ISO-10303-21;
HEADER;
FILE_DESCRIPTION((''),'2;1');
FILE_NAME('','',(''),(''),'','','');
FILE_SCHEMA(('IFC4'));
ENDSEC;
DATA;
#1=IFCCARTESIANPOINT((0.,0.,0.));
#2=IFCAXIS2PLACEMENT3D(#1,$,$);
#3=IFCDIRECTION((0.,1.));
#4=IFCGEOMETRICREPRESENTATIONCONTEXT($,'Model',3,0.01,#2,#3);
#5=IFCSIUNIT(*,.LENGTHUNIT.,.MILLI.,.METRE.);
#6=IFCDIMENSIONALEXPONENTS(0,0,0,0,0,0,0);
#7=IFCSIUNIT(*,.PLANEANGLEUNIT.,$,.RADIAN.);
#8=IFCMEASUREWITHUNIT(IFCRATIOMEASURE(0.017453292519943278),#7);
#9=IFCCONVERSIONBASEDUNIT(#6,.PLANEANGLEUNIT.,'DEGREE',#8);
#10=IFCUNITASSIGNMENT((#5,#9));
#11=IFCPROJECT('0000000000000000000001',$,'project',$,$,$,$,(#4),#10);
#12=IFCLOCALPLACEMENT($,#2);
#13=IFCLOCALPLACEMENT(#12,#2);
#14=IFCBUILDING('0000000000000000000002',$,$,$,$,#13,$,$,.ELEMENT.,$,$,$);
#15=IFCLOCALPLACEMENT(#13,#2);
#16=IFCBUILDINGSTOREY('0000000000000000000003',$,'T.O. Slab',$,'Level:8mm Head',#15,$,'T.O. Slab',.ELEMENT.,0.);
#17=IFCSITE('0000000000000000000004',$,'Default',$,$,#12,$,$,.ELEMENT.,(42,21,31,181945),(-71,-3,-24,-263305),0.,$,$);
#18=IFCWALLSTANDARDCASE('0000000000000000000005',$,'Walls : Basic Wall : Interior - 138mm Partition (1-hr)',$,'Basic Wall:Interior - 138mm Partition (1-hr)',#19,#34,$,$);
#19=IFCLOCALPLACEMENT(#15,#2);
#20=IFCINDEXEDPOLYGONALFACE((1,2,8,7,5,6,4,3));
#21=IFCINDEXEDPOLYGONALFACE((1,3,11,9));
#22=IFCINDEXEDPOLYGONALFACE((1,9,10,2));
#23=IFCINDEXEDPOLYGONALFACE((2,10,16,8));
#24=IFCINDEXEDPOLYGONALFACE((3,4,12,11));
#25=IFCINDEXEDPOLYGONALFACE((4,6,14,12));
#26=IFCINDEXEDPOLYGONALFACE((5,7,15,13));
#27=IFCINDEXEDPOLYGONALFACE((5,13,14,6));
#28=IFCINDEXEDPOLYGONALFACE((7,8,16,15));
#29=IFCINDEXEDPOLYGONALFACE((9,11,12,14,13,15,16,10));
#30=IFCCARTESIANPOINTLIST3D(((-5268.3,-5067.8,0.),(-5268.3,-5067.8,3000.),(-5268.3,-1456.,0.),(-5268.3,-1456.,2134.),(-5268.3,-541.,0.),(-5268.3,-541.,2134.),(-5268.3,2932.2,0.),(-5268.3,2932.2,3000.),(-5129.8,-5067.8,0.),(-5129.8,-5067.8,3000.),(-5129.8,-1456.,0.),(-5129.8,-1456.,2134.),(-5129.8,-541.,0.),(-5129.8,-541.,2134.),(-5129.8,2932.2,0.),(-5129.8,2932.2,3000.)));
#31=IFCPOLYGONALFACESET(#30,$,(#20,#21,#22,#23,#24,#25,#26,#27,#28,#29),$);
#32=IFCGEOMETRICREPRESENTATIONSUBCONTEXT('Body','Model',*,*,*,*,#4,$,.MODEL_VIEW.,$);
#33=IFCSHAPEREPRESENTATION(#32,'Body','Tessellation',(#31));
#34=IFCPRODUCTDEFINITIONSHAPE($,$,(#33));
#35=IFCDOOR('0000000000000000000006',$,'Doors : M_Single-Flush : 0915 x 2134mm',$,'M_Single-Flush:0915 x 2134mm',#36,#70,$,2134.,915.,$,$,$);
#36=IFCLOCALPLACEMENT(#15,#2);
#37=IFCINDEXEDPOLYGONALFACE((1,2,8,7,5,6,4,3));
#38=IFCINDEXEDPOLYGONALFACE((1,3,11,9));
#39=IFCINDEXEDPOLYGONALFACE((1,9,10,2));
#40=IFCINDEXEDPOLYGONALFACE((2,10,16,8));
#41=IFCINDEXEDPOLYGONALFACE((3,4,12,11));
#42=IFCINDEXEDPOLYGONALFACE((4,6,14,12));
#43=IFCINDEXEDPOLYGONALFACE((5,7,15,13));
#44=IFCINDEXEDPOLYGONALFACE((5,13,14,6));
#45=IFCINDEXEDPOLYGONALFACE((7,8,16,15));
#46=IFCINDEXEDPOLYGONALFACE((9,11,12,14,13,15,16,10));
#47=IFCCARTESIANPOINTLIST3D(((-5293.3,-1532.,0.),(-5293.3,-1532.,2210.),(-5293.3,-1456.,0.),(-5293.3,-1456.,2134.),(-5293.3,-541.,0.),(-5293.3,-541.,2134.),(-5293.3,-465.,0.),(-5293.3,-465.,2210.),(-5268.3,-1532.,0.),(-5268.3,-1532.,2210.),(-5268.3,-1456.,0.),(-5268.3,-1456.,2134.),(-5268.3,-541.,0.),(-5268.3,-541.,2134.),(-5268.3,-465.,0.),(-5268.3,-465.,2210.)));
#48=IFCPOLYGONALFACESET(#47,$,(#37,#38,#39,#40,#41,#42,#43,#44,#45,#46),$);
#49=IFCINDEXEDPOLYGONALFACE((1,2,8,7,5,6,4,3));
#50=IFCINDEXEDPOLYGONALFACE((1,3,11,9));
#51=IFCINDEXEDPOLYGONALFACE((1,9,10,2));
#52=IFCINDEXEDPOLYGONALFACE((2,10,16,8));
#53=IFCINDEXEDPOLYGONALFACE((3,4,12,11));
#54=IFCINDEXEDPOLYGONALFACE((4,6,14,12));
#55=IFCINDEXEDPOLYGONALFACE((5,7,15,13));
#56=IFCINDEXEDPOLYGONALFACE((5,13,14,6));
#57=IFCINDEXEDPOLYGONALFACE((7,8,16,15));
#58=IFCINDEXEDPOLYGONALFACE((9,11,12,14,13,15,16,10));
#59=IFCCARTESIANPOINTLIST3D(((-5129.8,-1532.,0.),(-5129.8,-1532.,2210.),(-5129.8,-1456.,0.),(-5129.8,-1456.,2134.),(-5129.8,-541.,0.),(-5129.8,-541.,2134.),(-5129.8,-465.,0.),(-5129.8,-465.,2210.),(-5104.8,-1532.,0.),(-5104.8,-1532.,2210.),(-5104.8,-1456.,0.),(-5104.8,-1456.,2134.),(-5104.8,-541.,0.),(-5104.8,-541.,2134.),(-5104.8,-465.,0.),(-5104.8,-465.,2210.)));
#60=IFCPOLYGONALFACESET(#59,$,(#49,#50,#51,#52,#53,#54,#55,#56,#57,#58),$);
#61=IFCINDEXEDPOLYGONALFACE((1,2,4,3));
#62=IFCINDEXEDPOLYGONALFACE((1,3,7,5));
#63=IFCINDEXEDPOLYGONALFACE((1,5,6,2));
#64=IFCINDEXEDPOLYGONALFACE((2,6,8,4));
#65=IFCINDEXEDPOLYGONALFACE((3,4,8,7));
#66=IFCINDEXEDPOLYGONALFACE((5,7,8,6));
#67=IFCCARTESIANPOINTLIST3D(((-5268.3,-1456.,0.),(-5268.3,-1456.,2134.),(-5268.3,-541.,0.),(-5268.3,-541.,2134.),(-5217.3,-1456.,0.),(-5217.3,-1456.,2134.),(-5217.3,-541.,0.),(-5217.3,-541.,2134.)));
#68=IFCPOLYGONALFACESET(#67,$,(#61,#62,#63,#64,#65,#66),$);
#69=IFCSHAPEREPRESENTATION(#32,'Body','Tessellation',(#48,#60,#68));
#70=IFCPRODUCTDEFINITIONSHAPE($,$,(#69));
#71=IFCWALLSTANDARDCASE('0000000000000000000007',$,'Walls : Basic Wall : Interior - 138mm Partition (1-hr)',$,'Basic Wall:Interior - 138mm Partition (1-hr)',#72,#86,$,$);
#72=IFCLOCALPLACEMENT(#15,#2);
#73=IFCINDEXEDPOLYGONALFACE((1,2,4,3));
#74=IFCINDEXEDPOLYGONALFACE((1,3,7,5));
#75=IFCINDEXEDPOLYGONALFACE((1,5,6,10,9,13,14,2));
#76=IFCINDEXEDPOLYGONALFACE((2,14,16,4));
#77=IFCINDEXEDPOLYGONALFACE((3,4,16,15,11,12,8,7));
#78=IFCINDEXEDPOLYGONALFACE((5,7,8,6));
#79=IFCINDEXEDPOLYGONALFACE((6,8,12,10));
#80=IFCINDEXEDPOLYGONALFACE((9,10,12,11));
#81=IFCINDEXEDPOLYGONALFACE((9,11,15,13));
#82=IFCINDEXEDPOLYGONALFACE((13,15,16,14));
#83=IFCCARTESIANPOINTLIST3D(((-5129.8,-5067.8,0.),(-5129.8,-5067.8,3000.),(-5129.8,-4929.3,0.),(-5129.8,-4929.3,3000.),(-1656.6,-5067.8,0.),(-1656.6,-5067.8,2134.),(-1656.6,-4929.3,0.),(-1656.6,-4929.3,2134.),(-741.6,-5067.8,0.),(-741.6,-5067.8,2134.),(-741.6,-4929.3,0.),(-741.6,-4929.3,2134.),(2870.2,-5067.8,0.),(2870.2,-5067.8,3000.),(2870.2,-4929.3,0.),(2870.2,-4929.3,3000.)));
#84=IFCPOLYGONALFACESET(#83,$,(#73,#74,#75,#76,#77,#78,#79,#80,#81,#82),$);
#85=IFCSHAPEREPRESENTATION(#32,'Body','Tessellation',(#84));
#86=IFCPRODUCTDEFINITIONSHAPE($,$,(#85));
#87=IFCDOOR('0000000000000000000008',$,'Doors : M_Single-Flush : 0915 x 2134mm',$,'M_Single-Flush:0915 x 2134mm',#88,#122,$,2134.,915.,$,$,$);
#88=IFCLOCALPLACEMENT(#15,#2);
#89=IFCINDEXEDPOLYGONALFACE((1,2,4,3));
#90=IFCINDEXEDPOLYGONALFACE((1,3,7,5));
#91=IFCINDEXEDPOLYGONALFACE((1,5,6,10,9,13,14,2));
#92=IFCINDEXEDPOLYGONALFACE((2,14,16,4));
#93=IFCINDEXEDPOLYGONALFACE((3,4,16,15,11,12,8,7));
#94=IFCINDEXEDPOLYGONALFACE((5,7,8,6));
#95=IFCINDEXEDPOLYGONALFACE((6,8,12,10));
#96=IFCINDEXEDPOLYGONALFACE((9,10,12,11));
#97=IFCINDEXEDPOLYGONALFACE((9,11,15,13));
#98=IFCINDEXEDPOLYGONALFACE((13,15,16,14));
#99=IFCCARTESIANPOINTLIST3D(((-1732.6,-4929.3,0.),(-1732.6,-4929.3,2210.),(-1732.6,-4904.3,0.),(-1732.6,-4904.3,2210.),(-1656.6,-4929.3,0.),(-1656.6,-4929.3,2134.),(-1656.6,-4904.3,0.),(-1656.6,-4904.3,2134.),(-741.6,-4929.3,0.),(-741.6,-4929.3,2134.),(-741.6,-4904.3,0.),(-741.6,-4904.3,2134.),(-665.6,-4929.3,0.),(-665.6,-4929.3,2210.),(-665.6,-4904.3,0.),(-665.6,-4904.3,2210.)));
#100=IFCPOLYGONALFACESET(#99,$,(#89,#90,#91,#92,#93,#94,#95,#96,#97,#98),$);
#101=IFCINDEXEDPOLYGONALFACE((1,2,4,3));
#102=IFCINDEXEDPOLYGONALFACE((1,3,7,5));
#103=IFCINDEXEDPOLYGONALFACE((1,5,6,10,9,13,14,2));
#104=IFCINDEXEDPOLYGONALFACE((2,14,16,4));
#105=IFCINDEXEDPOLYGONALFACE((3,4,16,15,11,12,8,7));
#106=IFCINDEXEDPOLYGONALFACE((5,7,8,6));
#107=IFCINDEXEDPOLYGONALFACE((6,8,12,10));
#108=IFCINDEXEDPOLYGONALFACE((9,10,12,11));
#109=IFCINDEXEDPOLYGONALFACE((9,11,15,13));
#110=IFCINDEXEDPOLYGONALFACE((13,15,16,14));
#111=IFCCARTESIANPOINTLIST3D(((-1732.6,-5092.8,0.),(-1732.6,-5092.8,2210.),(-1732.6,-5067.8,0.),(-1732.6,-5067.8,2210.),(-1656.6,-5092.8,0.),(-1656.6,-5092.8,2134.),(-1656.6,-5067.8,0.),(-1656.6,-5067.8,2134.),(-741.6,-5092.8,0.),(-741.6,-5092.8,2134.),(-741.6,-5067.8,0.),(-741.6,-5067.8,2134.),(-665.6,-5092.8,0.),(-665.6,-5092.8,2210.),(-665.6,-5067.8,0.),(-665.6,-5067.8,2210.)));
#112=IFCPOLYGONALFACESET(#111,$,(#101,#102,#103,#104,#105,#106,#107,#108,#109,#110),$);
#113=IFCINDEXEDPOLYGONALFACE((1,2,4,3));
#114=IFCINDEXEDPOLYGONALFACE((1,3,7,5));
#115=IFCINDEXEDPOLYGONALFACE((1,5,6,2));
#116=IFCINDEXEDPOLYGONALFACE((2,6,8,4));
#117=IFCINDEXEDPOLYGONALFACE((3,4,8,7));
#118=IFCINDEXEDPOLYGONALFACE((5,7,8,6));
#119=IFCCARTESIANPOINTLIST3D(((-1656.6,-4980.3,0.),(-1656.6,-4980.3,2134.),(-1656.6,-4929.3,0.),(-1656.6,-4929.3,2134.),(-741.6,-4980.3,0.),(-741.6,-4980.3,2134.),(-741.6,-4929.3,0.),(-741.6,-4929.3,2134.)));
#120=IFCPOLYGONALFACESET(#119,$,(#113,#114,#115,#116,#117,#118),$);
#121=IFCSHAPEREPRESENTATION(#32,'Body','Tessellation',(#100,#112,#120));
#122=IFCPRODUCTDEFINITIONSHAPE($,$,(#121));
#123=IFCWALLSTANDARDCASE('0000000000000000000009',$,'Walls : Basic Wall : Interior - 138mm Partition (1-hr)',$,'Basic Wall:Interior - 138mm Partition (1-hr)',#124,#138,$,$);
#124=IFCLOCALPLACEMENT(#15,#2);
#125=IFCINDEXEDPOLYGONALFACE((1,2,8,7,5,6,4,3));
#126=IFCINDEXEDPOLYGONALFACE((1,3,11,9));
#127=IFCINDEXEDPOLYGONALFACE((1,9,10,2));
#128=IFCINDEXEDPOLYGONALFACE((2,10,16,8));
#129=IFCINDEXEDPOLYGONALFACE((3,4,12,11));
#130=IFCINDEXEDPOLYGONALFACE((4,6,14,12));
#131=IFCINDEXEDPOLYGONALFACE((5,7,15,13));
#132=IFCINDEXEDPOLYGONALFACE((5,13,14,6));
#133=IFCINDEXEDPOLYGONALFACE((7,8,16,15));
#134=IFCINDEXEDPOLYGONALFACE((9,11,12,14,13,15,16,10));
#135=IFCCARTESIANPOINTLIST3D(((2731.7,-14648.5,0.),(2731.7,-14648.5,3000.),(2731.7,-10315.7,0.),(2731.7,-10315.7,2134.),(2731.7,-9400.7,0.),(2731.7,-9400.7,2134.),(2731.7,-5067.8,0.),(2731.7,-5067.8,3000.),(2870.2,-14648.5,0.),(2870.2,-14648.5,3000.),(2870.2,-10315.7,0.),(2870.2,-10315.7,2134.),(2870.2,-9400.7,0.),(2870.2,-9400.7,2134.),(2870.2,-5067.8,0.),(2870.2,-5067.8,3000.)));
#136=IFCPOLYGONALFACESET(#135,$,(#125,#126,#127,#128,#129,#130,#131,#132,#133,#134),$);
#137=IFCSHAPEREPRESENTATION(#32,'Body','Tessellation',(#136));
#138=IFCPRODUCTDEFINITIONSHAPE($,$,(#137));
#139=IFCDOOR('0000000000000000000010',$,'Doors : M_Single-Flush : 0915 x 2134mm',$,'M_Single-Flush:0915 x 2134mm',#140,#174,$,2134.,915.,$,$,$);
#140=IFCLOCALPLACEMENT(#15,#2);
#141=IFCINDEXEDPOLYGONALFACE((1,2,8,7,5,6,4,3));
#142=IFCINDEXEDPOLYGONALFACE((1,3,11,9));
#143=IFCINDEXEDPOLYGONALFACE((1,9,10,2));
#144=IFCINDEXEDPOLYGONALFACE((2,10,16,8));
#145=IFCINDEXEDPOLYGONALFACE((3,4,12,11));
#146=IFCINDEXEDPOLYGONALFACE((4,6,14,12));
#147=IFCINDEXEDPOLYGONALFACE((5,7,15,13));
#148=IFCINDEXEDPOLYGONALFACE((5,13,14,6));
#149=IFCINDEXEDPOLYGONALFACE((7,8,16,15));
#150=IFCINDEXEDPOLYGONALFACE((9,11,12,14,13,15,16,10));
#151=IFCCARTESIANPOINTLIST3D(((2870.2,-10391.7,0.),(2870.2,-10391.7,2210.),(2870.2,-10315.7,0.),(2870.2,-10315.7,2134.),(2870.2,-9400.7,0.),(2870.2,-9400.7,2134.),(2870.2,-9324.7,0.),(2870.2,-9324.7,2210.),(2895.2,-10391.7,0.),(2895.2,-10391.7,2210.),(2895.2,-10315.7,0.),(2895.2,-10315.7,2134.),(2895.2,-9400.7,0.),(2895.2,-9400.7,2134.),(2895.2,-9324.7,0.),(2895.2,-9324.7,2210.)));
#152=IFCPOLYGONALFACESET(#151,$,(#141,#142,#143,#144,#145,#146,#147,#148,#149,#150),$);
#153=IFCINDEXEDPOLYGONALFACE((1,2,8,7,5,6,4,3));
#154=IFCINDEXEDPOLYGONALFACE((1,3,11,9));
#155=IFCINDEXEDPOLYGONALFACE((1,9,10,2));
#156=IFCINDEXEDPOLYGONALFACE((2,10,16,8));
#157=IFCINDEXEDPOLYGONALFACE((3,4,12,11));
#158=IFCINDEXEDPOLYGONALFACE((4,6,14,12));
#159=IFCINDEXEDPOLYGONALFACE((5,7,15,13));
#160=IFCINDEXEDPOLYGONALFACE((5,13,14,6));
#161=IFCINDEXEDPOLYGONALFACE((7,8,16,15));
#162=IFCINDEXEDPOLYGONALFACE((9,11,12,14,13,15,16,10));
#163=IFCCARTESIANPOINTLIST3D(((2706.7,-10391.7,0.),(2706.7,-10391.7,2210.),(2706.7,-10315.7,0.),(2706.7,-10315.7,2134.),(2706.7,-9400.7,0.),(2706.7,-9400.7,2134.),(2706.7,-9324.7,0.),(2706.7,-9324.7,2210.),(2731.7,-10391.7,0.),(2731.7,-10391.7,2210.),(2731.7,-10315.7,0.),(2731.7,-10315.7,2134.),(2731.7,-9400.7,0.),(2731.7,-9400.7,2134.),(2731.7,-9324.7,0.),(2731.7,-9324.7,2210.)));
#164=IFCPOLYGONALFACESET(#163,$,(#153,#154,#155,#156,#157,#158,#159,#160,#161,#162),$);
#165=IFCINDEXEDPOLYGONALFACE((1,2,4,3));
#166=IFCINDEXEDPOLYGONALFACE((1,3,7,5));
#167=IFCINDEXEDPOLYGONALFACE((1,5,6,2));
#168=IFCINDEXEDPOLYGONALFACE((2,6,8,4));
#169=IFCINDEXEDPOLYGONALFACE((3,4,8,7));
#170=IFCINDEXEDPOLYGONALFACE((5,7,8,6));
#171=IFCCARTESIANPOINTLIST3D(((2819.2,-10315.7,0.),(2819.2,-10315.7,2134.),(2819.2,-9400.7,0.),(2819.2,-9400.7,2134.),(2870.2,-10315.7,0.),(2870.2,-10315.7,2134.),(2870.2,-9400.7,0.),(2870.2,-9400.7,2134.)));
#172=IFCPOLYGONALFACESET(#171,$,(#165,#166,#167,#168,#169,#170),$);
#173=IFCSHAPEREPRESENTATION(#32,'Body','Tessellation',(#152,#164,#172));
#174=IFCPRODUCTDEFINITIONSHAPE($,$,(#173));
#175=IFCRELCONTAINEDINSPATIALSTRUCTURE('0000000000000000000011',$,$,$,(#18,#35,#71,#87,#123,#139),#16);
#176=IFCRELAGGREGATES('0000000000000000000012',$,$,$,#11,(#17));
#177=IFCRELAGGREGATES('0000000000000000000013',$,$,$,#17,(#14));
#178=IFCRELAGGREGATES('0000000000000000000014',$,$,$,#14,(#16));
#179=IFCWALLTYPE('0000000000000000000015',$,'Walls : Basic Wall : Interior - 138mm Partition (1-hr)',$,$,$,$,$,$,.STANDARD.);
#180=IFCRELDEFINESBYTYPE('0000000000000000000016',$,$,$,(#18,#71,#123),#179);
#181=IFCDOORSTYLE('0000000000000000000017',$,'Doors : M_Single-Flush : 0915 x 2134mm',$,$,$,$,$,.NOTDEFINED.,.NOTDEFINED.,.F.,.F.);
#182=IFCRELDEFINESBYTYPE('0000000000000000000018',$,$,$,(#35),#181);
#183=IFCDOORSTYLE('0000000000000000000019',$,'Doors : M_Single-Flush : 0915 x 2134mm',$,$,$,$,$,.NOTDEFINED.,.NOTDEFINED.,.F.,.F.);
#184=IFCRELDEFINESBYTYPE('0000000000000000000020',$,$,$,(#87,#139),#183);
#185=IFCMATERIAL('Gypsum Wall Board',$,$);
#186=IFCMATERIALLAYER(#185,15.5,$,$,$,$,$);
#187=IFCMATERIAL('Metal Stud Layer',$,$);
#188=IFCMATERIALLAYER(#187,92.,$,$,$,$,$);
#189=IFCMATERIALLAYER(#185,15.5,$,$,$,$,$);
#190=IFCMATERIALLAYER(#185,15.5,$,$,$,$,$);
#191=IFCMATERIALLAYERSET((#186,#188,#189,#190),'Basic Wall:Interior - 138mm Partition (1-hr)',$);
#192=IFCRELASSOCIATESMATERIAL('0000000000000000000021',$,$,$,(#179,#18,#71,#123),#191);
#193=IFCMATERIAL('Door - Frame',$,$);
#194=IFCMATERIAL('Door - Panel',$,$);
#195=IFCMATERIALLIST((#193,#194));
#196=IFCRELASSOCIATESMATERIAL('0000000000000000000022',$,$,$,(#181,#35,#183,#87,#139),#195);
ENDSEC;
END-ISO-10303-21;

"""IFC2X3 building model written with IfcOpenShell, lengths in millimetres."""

from ifc_helpers import new_model, entity, si_unit, converted_unit, direction, frame, frame_2d, origin, place, context, subcontext, project, spatial, polyline, rectangle, outline, extrude, clip, halfspace, source, transform, mapped, material, material_list, layer, layer_set, layer_usage, type_object, type_shapes, element, fill, save


model = new_model("IFC2X3")

# Units and contexts
model_context = context("Model", 3, precision=0.01, world=origin(), true_north=direction((0.0, 1.0)))
body_context = subcontext(model_context, "Body", "Model", "MODEL_VIEW")
ifc_project = project(units=[si_unit("LENGTHUNIT", "METRE", prefix="MILLI"), converted_unit("PLANEANGLEUNIT", "DEGREE", entity("IfcRatioMeasure", 0.017453292519943278), si_unit("PLANEANGLEUNIT", "RADIAN"), dimensions=[0, 0, 0, 0, 0, 0, 0])], contexts=[model_context])

# Site, building, storey
site_placement = place(None, origin())
site = spatial("IfcSite", under=ifc_project, at=site_placement, Name="Default", CompositionType="ELEMENT", RefLatitude=(42, 21, 31, 181945), RefLongitude=(-71, -3, -24, -263305), RefElevation=0.0)
building_placement = place(site_placement, origin())
building = spatial("IfcBuilding", under=site, at=building_placement, CompositionType="ELEMENT")
storey_placement = place(building_placement, origin())
storey = spatial("IfcBuildingStorey", under=building, at=storey_placement, Name="T.O. Slab", ObjectType="Level:8mm Head", LongName="T.O. Slab", CompositionType="ELEMENT", Elevation=0.0)

# Shared definitions
ifc_material_1 = material(Name="Metal Stud Layer")
ifc_material_2 = material(Name="Gypsum Wall Board")

# Shared definitions
ifc_material_3 = material(Name="Door - Frame")
ifc_material_4 = material(Name="Door - Panel")
ifc_material_list = material_list([ifc_material_3, ifc_material_4])

# Shared definitions
ifc_layer_1 = layer(ifc_material_2, 15.5)
ifc_layer_2 = layer(ifc_material_1, 92.0)
ifc_layer_3 = layer(ifc_material_2, 15.5)
ifc_layer_4 = layer(ifc_material_2, 15.5)
ifc_layer_set_1 = layer_set([ifc_layer_1, ifc_layer_2, ifc_layer_3, ifc_layer_4], Name="Basic Wall:Interior - 138mm Partition (1-hr)")
wall_type_1 = type_object("IfcWallType", Name="Walls : Basic Wall : Interior - 138mm Partition (1-hr)", PredefinedType="STANDARD", material=ifc_layer_set_1)

# Walls, openings, doors
ifc_layer_usage_1 = layer_usage(ifc_layer_set_1, "AXIS2", "NEGATIVE", 69.2)
wall_1_placement = place(storey_placement, frame((-5199.1, 2932.2, 0.0), z_axis=(0.0, 0.0, 1.0), x_axis=(0.0, -1.0, 0.0)))
wall_1 = element("IfcWallStandardCase", 1, at=wall_1_placement, inside=storey, type_object=wall_type_1, material=ifc_layer_usage_1, Name="Walls : Basic Wall : Interior - 138mm Partition (1-hr)", ObjectType="Basic Wall:Interior - 138mm Partition (1-hr)", context=body_context, shape_type="Clipping", body=[
    clip(extrude(rectangle(XDim=8000.0, YDim=138.5, at=frame_2d((4000.0, 0.0), x_axis=(1.0, 0.0))), origin(), (0.0, 0.0, 1.0), 3000.0), halfspace(origin(), True)),
])
opening_1_placement = place(wall_1_placement, frame((4388.2, 69.3, 0.0)))
opening_1 = element("IfcOpeningElement", 2, at=opening_1_placement, cuts=wall_1, ObjectType="Opening", context=body_context, shape_type="SweptSolid", body=[
    extrude(rectangle(XDim=915.0, YDim=2134.0, at=frame_2d((1067.0, 457.5), x_axis=(0.0, -1.0))), frame((0.0, 0.0, 0.0), z_axis=(0.0, -1.0, 0.0), x_axis=(0.0, 0.0, 1.0)), (0.0, 0.0, 1.0), 138.5),
])
door_style_1 = type_object("IfcDoorStyle", Name="Doors : M_Single-Flush : 0915 x 2134mm", ConstructionType="NOTDEFINED", OperationType="NOTDEFINED", ParameterTakesPrecedence=False, Sizeable=False, material=ifc_material_list)
shared_shape_1 = source(origin(), body_context, "Body", "SweptSolid", [
    extrude(outline(polyline([(-533.5, -1124.0), (533.5, -1124.0), (533.5, 1086.0), (457.5, 1086.0), (457.5, -1048.0), (-457.5, -1048.0), (-457.5, 1086.0), (-533.5, 1086.0), (-533.5, -1124.0)])), frame((457.5, 163.5, 1086.0), z_axis=(0.0, -1.0, 0.0), x_axis=(-1.0, 0.0, 0.0)), (0.0, 0.0, 1.0), 25.0),
    extrude(outline(polyline([(-1124.0, -533.5), (1086.0, -533.5), (1086.0, -457.5), (-1048.0, -457.5), (-1048.0, 457.5), (1086.0, 457.5), (1086.0, 533.5), (-1124.0, 533.5), (-1124.0, -533.5)])), frame((457.5, 0.0, 1086.0), z_axis=(0.0, -1.0, 0.0), x_axis=(0.0, 0.0, -1.0)), (0.0, 0.0, 1.0), 25.0),
    extrude(rectangle(XDim=915.0, YDim=51.0, at=frame_2d((0.0, 0.0), x_axis=(1.0, 0.0))), frame((457.5, 113.0, 0.0)), (0.0, 0.0, 1.0), 2134.0),
])
type_shapes(door_style_1, [shared_shape_1])
door_1_placement = place(opening_1_placement, frame((0.0, 0.0, 0.0), z_axis=(0.0, 0.0, 1.0), x_axis=(-1.0, 0.0, 0.0)))
door_1 = element("IfcDoor", 3, at=door_1_placement, inside=storey, type_object=door_style_1, material=ifc_material_list, Name="Doors : M_Single-Flush : 0915 x 2134mm", ObjectType="M_Single-Flush:0915 x 2134mm", OverallHeight=2134.0, OverallWidth=915.0, context=body_context, shape_type="MappedRepresentation", body=[
    mapped(shared_shape_1, transform((0.0, 0.0, 0.0), scale=1.0)),
])
fill(opening_1, door_1)
wall_2_placement = place(storey_placement, frame((-5129.8, -4998.5, 0.0)))
wall_2 = element("IfcWallStandardCase", 4, at=wall_2_placement, inside=storey, type_object=wall_type_1, material=ifc_layer_usage_1, Name="Walls : Basic Wall : Interior - 138mm Partition (1-hr)", ObjectType="Basic Wall:Interior - 138mm Partition (1-hr)", context=body_context, shape_type="Clipping", body=[
    clip(extrude(rectangle(XDim=8000.0, YDim=138.5, at=frame_2d((4000.0, 0.0), x_axis=(1.0, 0.0))), origin(), (0.0, 0.0, 1.0), 3000.0), halfspace(origin(), True)),
])
opening_2_placement = place(wall_2_placement, frame((3473.2, -69.3, 0.0)))
opening_2 = element("IfcOpeningElement", 5, at=opening_2_placement, cuts=wall_2, ObjectType="Opening", context=body_context, shape_type="SweptSolid", body=[
    extrude(rectangle(XDim=915.0, YDim=2134.0, at=frame_2d((1067.0, 457.5), x_axis=(0.0, 1.0))), frame((0.0, 0.0, 0.0), z_axis=(0.0, 1.0, 0.0), x_axis=(0.0, 0.0, 1.0)), (0.0, 0.0, 1.0), 138.5),
])
door_style_2 = type_object("IfcDoorStyle", Name="Doors : M_Single-Flush : 0915 x 2134mm", ConstructionType="NOTDEFINED", OperationType="NOTDEFINED", ParameterTakesPrecedence=False, Sizeable=False, material=ifc_material_list)
shared_shape_2 = source(origin(), body_context, "Body", "SweptSolid", [
    extrude(outline(polyline([(-533.5, -1124.0), (533.5, -1124.0), (533.5, 1086.0), (457.5, 1086.0), (457.5, -1048.0), (-457.5, -1048.0), (-457.5, 1086.0), (-533.5, 1086.0), (-533.5, -1124.0)])), frame((457.5, 138.5, 1086.0), z_axis=(0.0, 1.0, 0.0), x_axis=(1.0, 0.0, 0.0)), (0.0, 0.0, 1.0), 25.0),
    extrude(outline(polyline([(-1124.0, -533.5), (1086.0, -533.5), (1086.0, -457.5), (-1048.0, -457.5), (-1048.0, 457.5), (1086.0, 457.5), (1086.0, 533.5), (-1124.0, 533.5), (-1124.0, -533.5)])), frame((457.5, -25.0, 1086.0), z_axis=(0.0, 1.0, 0.0), x_axis=(0.0, 0.0, -1.0)), (0.0, 0.0, 1.0), 25.0),
    extrude(rectangle(XDim=51.0, YDim=915.0, at=frame_2d((0.0, 0.0), x_axis=(1.0, 0.0))), frame((457.5, 113.0, 0.0), z_axis=(0.0, 0.0, 1.0), x_axis=(0.0, 1.0, 0.0)), (0.0, 0.0, 1.0), 2134.0),
])
type_shapes(door_style_2, [shared_shape_2])
door_2_placement = place(opening_2_placement, origin())
door_2 = element("IfcDoor", 6, at=door_2_placement, inside=storey, type_object=door_style_2, material=ifc_material_list, Name="Doors : M_Single-Flush : 0915 x 2134mm", ObjectType="M_Single-Flush:0915 x 2134mm", OverallHeight=2134.0, OverallWidth=915.0, context=body_context, shape_type="MappedRepresentation", body=[
    mapped(shared_shape_2, transform((0.0, 0.0, 0.0), scale=1.0)),
])
fill(opening_2, door_2)
wall_3_placement = place(storey_placement, frame((2800.9, -5067.8, 0.0), z_axis=(0.0, 0.0, 1.0), x_axis=(0.0, -1.0, 0.0)))
wall_3 = element("IfcWallStandardCase", 7, at=wall_3_placement, inside=storey, type_object=wall_type_1, material=ifc_layer_usage_1, Name="Walls : Basic Wall : Interior - 138mm Partition (1-hr)", ObjectType="Basic Wall:Interior - 138mm Partition (1-hr)", context=body_context, shape_type="Clipping", body=[
    clip(extrude(rectangle(XDim=9580.8, YDim=138.5, at=frame_2d((4790.4, 0.0), x_axis=(1.0, 0.0))), origin(), (0.0, 0.0, 1.0), 3000.0), halfspace(origin(), True)),
])
opening_3_placement = place(wall_3_placement, frame((4332.9, -69.3, 0.0)))
opening_3 = element("IfcOpeningElement", 8, at=opening_3_placement, cuts=wall_3, ObjectType="Opening", context=body_context, shape_type="SweptSolid", body=[
    extrude(rectangle(XDim=915.0, YDim=2134.0, at=frame_2d((1067.0, 457.5), x_axis=(0.0, 1.0))), frame((0.0, 0.0, 0.0), z_axis=(0.0, 1.0, 0.0), x_axis=(0.0, 0.0, 1.0)), (0.0, 0.0, 1.0), 138.5),
])
door_3_placement = place(opening_3_placement, origin())
door_3 = element("IfcDoor", 9, at=door_3_placement, inside=storey, type_object=door_style_2, material=ifc_material_list, Name="Doors : M_Single-Flush : 0915 x 2134mm", ObjectType="M_Single-Flush:0915 x 2134mm", OverallHeight=2134.0, OverallWidth=915.0, context=body_context, shape_type="MappedRepresentation", body=[
    mapped(shared_shape_2, transform((0.0, 0.0, 0.0), scale=1.0)),
])
fill(opening_3, door_3)

save(model, "model.ifc")
